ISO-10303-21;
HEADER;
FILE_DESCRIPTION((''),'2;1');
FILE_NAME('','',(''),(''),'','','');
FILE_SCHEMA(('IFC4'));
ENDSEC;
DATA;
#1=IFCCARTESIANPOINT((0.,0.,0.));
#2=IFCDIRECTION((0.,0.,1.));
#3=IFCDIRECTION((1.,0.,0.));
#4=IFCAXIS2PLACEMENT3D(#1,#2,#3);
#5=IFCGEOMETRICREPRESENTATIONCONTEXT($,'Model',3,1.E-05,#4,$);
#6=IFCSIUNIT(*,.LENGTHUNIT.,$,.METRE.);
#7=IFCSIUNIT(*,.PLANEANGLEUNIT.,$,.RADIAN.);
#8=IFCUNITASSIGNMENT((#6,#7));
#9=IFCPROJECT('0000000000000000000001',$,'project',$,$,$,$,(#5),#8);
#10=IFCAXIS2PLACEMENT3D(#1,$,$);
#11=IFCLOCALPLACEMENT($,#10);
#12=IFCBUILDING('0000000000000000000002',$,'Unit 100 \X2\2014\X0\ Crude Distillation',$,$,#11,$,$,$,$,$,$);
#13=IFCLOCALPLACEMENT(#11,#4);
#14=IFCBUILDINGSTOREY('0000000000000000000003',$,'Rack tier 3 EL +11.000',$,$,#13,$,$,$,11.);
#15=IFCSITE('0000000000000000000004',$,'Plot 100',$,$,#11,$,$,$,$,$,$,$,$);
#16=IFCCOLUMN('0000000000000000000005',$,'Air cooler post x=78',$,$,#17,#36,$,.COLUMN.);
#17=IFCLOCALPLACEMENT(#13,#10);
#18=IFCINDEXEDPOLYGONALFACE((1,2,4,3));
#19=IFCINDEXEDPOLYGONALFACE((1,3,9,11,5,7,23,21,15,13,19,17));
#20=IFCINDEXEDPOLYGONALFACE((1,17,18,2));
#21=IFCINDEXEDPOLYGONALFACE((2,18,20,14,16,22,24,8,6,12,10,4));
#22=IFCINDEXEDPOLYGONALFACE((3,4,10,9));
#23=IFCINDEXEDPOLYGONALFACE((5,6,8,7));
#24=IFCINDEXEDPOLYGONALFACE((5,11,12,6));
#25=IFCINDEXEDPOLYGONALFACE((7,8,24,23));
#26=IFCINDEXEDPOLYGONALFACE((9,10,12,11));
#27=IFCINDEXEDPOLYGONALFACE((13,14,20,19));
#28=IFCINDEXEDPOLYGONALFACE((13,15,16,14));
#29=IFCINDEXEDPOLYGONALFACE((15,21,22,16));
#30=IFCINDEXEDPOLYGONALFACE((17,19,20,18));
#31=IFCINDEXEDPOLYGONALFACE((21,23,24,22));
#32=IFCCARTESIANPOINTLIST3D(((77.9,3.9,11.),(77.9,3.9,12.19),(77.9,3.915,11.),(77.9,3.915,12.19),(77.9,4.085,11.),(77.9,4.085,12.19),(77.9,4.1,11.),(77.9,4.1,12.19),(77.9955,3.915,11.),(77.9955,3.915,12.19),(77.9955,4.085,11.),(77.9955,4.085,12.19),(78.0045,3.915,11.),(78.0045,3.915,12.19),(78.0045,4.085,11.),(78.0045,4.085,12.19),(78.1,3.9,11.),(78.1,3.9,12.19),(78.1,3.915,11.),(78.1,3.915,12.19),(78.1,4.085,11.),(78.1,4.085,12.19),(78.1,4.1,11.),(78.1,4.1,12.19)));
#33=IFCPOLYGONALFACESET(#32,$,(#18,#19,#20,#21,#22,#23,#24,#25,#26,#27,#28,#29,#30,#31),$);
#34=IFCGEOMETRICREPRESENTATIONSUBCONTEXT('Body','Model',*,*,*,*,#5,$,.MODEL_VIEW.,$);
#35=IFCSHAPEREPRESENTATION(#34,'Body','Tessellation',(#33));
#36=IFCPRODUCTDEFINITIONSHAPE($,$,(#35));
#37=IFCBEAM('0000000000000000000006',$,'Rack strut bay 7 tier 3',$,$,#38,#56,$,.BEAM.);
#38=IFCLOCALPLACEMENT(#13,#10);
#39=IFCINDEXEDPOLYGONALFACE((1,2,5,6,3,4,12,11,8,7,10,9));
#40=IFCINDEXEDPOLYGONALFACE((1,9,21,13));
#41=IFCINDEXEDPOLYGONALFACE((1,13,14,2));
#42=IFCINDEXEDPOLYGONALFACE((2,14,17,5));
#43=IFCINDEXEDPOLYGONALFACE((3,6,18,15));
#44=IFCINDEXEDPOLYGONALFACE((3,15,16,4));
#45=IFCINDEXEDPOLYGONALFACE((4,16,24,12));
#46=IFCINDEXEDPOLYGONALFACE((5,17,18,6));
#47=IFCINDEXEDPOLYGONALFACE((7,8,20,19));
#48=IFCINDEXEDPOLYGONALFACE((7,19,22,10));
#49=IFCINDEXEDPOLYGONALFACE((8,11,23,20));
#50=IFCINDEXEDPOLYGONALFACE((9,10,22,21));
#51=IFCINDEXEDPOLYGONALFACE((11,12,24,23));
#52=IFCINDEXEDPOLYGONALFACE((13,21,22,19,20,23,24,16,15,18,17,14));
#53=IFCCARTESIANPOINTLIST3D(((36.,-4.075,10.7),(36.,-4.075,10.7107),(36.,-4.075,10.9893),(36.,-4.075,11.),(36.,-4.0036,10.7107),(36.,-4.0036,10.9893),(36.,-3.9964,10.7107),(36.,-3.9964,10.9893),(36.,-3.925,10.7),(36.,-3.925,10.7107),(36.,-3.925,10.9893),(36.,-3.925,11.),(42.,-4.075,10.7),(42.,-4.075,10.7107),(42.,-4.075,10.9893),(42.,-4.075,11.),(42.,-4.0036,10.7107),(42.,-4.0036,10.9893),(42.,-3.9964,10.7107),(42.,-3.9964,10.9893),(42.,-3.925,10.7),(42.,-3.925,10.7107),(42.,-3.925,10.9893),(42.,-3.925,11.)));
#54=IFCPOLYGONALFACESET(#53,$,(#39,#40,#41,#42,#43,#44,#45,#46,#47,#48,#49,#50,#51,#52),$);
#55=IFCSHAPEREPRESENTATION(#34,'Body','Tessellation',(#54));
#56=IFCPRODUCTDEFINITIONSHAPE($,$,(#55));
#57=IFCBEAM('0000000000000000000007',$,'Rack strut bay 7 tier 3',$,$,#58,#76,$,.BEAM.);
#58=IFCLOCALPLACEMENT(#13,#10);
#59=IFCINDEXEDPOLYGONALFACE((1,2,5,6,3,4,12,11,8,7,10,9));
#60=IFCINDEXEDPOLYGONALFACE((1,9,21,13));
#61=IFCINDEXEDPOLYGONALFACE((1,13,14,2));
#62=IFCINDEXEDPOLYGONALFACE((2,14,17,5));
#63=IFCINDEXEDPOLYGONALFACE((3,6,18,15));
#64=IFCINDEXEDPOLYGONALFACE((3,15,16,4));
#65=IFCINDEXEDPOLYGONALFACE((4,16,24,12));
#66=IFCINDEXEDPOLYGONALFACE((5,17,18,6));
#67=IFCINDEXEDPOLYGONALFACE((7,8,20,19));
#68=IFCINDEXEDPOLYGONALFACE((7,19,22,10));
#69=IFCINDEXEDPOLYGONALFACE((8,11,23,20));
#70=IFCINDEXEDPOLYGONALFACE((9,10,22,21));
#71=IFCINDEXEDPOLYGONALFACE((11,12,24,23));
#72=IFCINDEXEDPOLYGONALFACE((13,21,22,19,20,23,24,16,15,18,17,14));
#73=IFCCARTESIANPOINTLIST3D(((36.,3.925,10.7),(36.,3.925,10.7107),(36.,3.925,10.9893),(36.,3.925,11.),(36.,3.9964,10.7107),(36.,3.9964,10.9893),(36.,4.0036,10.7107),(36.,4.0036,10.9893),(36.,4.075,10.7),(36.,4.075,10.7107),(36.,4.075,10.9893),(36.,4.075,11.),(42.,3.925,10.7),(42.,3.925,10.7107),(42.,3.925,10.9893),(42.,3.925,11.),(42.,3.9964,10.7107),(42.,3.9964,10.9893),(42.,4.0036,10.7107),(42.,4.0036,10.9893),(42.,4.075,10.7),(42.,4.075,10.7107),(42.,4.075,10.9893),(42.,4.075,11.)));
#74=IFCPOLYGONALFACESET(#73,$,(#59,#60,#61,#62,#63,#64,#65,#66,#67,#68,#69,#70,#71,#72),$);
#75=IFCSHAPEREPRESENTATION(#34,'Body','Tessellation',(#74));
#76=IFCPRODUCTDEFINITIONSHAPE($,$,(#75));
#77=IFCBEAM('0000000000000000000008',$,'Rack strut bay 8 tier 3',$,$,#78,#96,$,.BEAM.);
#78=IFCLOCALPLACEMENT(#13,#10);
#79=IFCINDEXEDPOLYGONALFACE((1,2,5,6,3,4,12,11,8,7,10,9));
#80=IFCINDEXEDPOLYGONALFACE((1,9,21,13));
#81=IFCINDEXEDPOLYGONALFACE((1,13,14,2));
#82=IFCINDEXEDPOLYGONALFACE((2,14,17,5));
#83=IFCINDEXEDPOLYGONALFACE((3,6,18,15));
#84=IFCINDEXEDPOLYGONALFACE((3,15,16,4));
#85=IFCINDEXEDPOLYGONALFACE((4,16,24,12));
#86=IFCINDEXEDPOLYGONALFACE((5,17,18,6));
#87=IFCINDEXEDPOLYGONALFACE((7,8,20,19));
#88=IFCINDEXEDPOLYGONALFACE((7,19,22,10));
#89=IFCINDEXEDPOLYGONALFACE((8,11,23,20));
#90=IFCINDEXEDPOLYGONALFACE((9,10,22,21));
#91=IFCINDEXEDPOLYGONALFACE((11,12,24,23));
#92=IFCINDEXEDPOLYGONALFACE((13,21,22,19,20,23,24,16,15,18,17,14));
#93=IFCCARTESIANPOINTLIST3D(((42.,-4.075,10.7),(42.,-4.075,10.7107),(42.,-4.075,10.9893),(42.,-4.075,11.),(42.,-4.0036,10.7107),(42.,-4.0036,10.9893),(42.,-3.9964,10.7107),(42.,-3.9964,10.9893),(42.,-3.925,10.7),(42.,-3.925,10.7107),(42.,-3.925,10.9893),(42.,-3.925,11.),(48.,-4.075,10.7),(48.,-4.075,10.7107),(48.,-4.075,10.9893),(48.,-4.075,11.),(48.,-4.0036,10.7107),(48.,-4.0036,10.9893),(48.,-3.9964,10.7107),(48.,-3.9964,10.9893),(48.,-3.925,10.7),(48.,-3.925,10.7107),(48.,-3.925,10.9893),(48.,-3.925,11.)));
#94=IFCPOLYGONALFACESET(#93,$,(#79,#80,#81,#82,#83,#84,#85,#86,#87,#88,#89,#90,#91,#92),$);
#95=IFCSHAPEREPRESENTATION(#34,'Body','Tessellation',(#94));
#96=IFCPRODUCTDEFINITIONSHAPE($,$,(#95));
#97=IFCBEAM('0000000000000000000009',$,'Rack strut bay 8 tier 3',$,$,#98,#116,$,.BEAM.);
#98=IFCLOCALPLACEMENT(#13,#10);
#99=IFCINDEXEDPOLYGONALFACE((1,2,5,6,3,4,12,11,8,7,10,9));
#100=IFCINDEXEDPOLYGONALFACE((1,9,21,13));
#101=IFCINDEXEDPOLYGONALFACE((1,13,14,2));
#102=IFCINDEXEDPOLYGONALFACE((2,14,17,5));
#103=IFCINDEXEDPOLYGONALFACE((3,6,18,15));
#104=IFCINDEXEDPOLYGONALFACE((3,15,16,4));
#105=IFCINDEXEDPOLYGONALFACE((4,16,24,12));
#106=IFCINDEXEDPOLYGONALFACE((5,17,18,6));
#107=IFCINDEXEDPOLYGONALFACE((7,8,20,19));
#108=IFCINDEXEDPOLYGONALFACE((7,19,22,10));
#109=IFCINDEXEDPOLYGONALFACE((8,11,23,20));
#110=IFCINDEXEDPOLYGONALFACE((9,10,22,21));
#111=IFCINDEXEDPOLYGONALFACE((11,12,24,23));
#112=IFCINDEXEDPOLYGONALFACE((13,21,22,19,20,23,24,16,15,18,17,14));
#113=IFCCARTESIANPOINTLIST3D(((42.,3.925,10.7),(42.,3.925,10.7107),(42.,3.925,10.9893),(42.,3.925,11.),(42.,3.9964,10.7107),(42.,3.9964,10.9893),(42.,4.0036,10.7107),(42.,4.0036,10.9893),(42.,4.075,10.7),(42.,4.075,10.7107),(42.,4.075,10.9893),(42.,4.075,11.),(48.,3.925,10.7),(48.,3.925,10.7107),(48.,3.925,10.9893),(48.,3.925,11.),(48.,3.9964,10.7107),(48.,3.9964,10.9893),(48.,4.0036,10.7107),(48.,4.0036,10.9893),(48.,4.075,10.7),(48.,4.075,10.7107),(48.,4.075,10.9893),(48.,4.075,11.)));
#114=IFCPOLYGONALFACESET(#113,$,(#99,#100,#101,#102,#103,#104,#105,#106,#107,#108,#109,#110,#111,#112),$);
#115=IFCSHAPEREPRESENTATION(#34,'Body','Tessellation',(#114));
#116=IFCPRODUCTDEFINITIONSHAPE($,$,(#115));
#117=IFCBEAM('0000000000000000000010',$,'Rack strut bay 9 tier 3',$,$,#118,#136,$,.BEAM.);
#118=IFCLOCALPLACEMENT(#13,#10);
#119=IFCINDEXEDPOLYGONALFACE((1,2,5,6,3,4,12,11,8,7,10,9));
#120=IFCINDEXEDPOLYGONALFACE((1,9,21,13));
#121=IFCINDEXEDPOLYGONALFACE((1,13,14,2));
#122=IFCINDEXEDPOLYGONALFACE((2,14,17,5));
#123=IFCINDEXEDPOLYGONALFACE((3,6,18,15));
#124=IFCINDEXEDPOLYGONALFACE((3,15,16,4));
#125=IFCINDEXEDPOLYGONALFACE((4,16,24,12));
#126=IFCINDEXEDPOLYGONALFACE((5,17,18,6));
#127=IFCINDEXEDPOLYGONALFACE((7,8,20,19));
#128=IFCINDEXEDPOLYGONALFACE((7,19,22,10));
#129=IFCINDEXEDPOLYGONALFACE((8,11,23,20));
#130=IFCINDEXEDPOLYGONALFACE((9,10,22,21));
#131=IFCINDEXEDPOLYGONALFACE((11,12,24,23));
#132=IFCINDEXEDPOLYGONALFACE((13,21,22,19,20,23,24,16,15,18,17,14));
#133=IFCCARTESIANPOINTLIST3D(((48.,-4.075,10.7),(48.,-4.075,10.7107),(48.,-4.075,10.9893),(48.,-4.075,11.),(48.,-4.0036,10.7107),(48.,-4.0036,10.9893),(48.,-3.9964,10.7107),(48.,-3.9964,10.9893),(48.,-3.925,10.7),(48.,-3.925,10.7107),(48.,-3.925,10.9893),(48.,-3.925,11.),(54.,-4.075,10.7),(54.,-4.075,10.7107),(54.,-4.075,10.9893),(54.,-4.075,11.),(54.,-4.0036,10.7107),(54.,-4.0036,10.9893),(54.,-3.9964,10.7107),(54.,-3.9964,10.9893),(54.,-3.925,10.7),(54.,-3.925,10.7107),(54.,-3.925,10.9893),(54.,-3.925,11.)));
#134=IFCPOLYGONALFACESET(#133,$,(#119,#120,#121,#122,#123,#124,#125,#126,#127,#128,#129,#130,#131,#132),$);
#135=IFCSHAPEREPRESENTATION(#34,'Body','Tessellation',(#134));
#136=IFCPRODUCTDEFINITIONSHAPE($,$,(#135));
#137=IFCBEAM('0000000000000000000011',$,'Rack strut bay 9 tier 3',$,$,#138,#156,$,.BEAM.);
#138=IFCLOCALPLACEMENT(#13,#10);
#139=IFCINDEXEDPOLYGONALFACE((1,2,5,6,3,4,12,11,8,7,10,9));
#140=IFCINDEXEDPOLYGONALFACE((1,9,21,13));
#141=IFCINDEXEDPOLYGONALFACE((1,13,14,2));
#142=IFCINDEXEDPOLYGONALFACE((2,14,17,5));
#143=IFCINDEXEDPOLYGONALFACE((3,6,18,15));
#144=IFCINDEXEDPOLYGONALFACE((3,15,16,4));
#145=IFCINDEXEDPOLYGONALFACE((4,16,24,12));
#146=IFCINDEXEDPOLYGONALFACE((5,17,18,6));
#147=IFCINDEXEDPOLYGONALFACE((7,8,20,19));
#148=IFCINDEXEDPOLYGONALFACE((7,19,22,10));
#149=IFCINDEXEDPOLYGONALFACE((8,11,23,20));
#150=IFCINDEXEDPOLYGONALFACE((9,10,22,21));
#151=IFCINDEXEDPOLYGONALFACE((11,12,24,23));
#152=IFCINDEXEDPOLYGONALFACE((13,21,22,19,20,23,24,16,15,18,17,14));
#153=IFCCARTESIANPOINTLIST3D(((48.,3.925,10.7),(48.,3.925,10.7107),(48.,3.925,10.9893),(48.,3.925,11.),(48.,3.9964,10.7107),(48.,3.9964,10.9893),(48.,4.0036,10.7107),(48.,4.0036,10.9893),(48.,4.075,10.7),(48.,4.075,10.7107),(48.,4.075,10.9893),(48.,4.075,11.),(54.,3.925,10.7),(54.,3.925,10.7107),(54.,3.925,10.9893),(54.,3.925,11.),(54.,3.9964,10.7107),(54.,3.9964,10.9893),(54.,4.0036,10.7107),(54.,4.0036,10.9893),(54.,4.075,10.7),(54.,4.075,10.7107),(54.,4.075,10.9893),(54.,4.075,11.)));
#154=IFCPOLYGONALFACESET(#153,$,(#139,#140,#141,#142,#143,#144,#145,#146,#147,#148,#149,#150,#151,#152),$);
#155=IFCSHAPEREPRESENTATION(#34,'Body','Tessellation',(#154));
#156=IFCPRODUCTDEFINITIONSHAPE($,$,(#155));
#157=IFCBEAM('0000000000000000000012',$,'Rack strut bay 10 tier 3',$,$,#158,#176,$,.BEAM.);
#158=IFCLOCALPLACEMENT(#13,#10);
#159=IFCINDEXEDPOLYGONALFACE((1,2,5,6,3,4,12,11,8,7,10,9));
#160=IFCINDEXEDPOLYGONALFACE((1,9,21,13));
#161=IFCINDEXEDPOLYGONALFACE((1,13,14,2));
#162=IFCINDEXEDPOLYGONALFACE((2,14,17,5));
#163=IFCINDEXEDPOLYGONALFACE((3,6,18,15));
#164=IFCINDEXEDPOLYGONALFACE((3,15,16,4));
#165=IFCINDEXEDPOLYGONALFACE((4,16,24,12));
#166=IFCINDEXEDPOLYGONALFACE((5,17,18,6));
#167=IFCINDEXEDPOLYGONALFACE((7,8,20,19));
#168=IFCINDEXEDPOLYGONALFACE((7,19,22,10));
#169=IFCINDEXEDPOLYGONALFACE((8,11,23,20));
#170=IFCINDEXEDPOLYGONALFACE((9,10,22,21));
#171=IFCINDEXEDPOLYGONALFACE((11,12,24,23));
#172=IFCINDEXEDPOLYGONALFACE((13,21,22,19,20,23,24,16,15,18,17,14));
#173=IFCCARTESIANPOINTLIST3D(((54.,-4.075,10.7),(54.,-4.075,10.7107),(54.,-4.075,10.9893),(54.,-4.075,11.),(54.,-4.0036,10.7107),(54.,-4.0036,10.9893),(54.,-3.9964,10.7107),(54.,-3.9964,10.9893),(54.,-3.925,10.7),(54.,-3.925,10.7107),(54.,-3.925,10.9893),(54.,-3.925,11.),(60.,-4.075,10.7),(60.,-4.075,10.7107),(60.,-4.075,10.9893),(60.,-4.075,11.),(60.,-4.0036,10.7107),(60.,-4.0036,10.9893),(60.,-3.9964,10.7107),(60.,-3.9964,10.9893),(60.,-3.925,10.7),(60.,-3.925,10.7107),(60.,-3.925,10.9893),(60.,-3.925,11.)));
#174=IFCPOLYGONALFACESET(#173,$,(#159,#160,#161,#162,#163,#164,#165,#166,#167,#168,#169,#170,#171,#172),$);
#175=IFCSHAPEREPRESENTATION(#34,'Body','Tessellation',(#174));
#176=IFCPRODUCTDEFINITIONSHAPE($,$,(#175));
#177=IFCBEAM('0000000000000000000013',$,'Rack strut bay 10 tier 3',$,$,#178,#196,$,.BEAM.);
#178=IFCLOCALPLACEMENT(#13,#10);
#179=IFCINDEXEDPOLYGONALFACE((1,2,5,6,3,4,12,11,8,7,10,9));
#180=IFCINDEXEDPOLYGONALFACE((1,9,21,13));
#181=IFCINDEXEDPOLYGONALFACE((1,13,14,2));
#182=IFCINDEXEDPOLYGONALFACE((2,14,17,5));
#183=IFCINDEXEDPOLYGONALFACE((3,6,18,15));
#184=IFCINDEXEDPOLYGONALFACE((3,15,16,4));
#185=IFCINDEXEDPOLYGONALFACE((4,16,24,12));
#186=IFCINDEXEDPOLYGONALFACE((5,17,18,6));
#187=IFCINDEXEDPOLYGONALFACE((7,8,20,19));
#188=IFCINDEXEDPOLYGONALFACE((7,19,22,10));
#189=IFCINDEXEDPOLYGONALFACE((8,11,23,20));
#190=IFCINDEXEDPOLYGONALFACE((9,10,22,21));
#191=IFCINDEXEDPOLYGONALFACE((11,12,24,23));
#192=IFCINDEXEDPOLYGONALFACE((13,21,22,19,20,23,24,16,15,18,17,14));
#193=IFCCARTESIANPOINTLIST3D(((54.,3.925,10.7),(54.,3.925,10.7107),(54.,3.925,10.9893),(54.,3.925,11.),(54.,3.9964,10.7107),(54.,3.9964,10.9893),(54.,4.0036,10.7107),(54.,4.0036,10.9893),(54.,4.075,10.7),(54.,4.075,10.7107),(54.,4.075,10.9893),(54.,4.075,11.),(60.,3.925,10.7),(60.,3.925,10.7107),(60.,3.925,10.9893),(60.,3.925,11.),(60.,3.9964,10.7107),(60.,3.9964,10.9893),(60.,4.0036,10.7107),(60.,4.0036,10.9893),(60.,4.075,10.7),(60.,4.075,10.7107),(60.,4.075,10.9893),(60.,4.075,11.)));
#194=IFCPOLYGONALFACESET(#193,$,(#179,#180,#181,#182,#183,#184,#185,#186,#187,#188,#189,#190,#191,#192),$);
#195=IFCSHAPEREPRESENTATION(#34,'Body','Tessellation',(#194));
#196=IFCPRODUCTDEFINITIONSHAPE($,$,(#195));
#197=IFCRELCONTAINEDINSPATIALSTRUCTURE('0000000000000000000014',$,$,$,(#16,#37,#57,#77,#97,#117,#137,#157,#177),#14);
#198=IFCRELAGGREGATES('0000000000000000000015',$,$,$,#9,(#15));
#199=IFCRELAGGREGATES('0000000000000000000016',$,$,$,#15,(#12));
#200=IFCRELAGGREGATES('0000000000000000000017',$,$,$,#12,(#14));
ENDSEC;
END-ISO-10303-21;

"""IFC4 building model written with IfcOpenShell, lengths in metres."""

from ifc_helpers import new_model, si_unit, frame, origin, origin_with_axes, origin_2d, place, context, subcontext, project, spatial, i_section, extrude, element, save


model = new_model("IFC4")

# Units and contexts
model_context = context("Model", 3, precision=1e-05, world=origin_with_axes())
body_context = subcontext(model_context, "Body", "Model", "MODEL_VIEW")
ifc_project = project(units=[si_unit("LENGTHUNIT", "METRE"), si_unit("PLANEANGLEUNIT", "RADIAN")], contexts=[model_context])

# Site, building, storey
placement = place(None, origin())
site = spatial("IfcSite", under=ifc_project, at=placement, Name="Plot 100")
building = spatial("IfcBuilding", under=site, at=placement, Name="Unit 100 — Crude Distillation")
storey_placement = place(placement, origin_with_axes())
storey = spatial("IfcBuildingStorey", under=building, at=storey_placement, Name="Rack tier 3 EL +11.000", Elevation=11.0)

# Column
column_1_placement = place(storey_placement, origin_with_axes())
element("IfcColumn", 1, at=column_1_placement, inside=storey, Name="Air cooler post x=78", PredefinedType="COLUMN", context=body_context, shape_type="SweptSolid", body=[
    extrude(i_section(OverallWidth=0.2, OverallDepth=0.2, WebThickness=0.009, FlangeThickness=0.015, at=origin_2d()), frame((78.0, 4.0, 11.0), z_axis=(0.0, 0.0, 1.0), x_axis=(1.0, 0.0, 0.0)), (0.0, 0.0, 1.0), 1.19),
])

# Beams
beam_1_placement = place(storey_placement, origin_with_axes())
element("IfcBeam", 2, at=beam_1_placement, inside=storey, Name="Rack strut bay 7 tier 3", PredefinedType="BEAM", context=body_context, shape_type="SweptSolid", body=[
    extrude(i_section(OverallWidth=0.15, OverallDepth=0.3, WebThickness=0.0071, FlangeThickness=0.0107, at=origin_2d()), frame((36.0, -4.0, 10.85), z_axis=(1.0, 0.0, 0.0), x_axis=(0.0, 1.0, 0.0)), (0.0, 0.0, 1.0), 6.0),
])
beam_2_placement = place(storey_placement, origin_with_axes())
element("IfcBeam", 3, at=beam_2_placement, inside=storey, Name="Rack strut bay 7 tier 3", PredefinedType="BEAM", context=body_context, shape_type="SweptSolid", body=[
    extrude(i_section(OverallWidth=0.15, OverallDepth=0.3, WebThickness=0.0071, FlangeThickness=0.0107, at=origin_2d()), frame((36.0, 4.0, 10.85), z_axis=(1.0, 0.0, 0.0), x_axis=(0.0, 1.0, 0.0)), (0.0, 0.0, 1.0), 6.0),
])
beam_3_placement = place(storey_placement, origin_with_axes())
element("IfcBeam", 4, at=beam_3_placement, inside=storey, Name="Rack strut bay 8 tier 3", PredefinedType="BEAM", context=body_context, shape_type="SweptSolid", body=[
    extrude(i_section(OverallWidth=0.15, OverallDepth=0.3, WebThickness=0.0071, FlangeThickness=0.0107, at=origin_2d()), frame((42.0, -4.0, 10.85), z_axis=(1.0, 0.0, 0.0), x_axis=(0.0, 1.0, 0.0)), (0.0, 0.0, 1.0), 6.0),
])
beam_4_placement = place(storey_placement, origin_with_axes())
element("IfcBeam", 5, at=beam_4_placement, inside=storey, Name="Rack strut bay 8 tier 3", PredefinedType="BEAM", context=body_context, shape_type="SweptSolid", body=[
    extrude(i_section(OverallWidth=0.15, OverallDepth=0.3, WebThickness=0.0071, FlangeThickness=0.0107, at=origin_2d()), frame((42.0, 4.0, 10.85), z_axis=(1.0, 0.0, 0.0), x_axis=(0.0, 1.0, 0.0)), (0.0, 0.0, 1.0), 6.0),
])
beam_5_placement = place(storey_placement, origin_with_axes())
element("IfcBeam", 6, at=beam_5_placement, inside=storey, Name="Rack strut bay 9 tier 3", PredefinedType="BEAM", context=body_context, shape_type="SweptSolid", body=[
    extrude(i_section(OverallWidth=0.15, OverallDepth=0.3, WebThickness=0.0071, FlangeThickness=0.0107, at=origin_2d()), frame((48.0, -4.0, 10.85), z_axis=(1.0, 0.0, 0.0), x_axis=(0.0, 1.0, 0.0)), (0.0, 0.0, 1.0), 6.0),
])
beam_6_placement = place(storey_placement, origin_with_axes())
element("IfcBeam", 7, at=beam_6_placement, inside=storey, Name="Rack strut bay 9 tier 3", PredefinedType="BEAM", context=body_context, shape_type="SweptSolid", body=[
    extrude(i_section(OverallWidth=0.15, OverallDepth=0.3, WebThickness=0.0071, FlangeThickness=0.0107, at=origin_2d()), frame((48.0, 4.0, 10.85), z_axis=(1.0, 0.0, 0.0), x_axis=(0.0, 1.0, 0.0)), (0.0, 0.0, 1.0), 6.0),
])
beam_7_placement = place(storey_placement, origin_with_axes())
element("IfcBeam", 8, at=beam_7_placement, inside=storey, Name="Rack strut bay 10 tier 3", PredefinedType="BEAM", context=body_context, shape_type="SweptSolid", body=[
    extrude(i_section(OverallWidth=0.15, OverallDepth=0.3, WebThickness=0.0071, FlangeThickness=0.0107, at=origin_2d()), frame((54.0, -4.0, 10.85), z_axis=(1.0, 0.0, 0.0), x_axis=(0.0, 1.0, 0.0)), (0.0, 0.0, 1.0), 6.0),
])
beam_8_placement = place(storey_placement, origin_with_axes())
element("IfcBeam", 9, at=beam_8_placement, inside=storey, Name="Rack strut bay 10 tier 3", PredefinedType="BEAM", context=body_context, shape_type="SweptSolid", body=[
    extrude(i_section(OverallWidth=0.15, OverallDepth=0.3, WebThickness=0.0071, FlangeThickness=0.0107, at=origin_2d()), frame((54.0, 4.0, 10.85), z_axis=(1.0, 0.0, 0.0), x_axis=(0.0, 1.0, 0.0)), (0.0, 0.0, 1.0), 6.0),
])

save(model, "model.ifc")
